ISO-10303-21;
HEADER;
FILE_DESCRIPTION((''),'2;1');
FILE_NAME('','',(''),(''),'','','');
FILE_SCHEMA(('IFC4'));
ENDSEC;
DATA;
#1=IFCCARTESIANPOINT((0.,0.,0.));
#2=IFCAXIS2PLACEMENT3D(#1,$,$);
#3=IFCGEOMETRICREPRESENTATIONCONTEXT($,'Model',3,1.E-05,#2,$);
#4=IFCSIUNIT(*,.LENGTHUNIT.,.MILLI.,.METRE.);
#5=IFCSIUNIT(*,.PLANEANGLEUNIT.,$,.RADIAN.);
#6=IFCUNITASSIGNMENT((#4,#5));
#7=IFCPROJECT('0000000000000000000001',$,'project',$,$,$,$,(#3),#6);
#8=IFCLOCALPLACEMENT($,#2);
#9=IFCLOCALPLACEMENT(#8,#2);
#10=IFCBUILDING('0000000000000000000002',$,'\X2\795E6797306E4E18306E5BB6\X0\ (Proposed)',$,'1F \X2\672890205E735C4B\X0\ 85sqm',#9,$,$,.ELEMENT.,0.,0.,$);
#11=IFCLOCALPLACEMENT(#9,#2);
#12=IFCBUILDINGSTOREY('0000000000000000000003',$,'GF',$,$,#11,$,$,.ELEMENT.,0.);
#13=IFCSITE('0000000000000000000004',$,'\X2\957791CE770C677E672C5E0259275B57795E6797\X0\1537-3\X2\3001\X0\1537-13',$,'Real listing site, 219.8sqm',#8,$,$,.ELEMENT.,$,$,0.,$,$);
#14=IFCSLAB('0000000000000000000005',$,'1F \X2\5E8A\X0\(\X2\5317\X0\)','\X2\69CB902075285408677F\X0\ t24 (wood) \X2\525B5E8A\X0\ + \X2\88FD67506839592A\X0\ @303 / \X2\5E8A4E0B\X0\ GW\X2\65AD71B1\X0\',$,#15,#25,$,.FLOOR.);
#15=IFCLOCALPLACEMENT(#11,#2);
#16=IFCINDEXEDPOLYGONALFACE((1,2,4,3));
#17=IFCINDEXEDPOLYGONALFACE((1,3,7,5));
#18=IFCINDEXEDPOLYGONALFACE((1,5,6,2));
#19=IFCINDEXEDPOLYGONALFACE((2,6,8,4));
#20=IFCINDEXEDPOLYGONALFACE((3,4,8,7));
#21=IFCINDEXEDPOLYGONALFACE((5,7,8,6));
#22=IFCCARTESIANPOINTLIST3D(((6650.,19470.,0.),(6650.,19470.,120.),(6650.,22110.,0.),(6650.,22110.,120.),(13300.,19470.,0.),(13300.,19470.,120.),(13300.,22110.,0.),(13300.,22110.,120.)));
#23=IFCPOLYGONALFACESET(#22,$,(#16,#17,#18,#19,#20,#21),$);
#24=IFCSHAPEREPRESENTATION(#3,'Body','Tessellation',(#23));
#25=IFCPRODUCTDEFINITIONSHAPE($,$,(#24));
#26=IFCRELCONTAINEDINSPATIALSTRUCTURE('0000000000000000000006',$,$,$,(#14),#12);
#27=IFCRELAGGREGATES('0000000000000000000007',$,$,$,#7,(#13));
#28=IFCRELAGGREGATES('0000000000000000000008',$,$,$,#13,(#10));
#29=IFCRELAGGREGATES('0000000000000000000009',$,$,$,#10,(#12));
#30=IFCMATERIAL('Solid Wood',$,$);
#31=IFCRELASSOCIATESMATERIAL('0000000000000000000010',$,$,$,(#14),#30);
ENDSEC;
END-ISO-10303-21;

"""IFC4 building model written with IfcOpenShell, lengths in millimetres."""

from ifc_helpers import new_model, si_unit, frame, frame_2d, origin, place, context, project, spatial, rectangle, extrude, material, element, save


model = new_model("IFC4")

# Units and contexts
model_context = context("Model", 3, precision=1e-05, world=origin())
ifc_project = project(units=[si_unit("LENGTHUNIT", "METRE", prefix="MILLI"), si_unit("PLANEANGLEUNIT", "RADIAN")], contexts=[model_context])

# Site, building, storey
site_placement = place(None, origin())
site = spatial("IfcSite", under=ifc_project, at=site_placement, Name="長野県松本市大字神林1537-3、1537-13", ObjectType="Real listing site, 219.8sqm", CompositionType="ELEMENT", RefElevation=0.0)
building_placement = place(site_placement, origin())
building = spatial("IfcBuilding", under=site, at=building_placement, Name="神林の丘の家 (Proposed)", ObjectType="1F 木造平屋 85sqm", CompositionType="ELEMENT", ElevationOfRefHeight=0.0, ElevationOfTerrain=0.0)
storey_placement = place(building_placement, origin())
storey = spatial("IfcBuildingStorey", under=building, at=storey_placement, Name="GF", CompositionType="ELEMENT", Elevation=0.0)

# Slab
ifc_material_1 = material(Name="Solid Wood")
slab_1_placement = place(storey_placement, frame((3325.0, 9735.0, 0.0)))
element("IfcSlab", 1, at=slab_1_placement, inside=storey, material=ifc_material_1, Name="1F 床(北)", Description="構造用合板 t24 (wood) 剛床 + 製材根太 @303 / 床下 GW断熱", PredefinedType="FLOOR", context=model_context, shape_type="SweptSolid", body=[
    extrude(rectangle(XDim=6650.0, YDim=2640.0, at=frame_2d((3325.0, 1320.0))), frame((3325.0, 9735.0, 0.0)), (0.0, 0.0, 1.0), 120.0),
])

save(model, "model.ifc")
